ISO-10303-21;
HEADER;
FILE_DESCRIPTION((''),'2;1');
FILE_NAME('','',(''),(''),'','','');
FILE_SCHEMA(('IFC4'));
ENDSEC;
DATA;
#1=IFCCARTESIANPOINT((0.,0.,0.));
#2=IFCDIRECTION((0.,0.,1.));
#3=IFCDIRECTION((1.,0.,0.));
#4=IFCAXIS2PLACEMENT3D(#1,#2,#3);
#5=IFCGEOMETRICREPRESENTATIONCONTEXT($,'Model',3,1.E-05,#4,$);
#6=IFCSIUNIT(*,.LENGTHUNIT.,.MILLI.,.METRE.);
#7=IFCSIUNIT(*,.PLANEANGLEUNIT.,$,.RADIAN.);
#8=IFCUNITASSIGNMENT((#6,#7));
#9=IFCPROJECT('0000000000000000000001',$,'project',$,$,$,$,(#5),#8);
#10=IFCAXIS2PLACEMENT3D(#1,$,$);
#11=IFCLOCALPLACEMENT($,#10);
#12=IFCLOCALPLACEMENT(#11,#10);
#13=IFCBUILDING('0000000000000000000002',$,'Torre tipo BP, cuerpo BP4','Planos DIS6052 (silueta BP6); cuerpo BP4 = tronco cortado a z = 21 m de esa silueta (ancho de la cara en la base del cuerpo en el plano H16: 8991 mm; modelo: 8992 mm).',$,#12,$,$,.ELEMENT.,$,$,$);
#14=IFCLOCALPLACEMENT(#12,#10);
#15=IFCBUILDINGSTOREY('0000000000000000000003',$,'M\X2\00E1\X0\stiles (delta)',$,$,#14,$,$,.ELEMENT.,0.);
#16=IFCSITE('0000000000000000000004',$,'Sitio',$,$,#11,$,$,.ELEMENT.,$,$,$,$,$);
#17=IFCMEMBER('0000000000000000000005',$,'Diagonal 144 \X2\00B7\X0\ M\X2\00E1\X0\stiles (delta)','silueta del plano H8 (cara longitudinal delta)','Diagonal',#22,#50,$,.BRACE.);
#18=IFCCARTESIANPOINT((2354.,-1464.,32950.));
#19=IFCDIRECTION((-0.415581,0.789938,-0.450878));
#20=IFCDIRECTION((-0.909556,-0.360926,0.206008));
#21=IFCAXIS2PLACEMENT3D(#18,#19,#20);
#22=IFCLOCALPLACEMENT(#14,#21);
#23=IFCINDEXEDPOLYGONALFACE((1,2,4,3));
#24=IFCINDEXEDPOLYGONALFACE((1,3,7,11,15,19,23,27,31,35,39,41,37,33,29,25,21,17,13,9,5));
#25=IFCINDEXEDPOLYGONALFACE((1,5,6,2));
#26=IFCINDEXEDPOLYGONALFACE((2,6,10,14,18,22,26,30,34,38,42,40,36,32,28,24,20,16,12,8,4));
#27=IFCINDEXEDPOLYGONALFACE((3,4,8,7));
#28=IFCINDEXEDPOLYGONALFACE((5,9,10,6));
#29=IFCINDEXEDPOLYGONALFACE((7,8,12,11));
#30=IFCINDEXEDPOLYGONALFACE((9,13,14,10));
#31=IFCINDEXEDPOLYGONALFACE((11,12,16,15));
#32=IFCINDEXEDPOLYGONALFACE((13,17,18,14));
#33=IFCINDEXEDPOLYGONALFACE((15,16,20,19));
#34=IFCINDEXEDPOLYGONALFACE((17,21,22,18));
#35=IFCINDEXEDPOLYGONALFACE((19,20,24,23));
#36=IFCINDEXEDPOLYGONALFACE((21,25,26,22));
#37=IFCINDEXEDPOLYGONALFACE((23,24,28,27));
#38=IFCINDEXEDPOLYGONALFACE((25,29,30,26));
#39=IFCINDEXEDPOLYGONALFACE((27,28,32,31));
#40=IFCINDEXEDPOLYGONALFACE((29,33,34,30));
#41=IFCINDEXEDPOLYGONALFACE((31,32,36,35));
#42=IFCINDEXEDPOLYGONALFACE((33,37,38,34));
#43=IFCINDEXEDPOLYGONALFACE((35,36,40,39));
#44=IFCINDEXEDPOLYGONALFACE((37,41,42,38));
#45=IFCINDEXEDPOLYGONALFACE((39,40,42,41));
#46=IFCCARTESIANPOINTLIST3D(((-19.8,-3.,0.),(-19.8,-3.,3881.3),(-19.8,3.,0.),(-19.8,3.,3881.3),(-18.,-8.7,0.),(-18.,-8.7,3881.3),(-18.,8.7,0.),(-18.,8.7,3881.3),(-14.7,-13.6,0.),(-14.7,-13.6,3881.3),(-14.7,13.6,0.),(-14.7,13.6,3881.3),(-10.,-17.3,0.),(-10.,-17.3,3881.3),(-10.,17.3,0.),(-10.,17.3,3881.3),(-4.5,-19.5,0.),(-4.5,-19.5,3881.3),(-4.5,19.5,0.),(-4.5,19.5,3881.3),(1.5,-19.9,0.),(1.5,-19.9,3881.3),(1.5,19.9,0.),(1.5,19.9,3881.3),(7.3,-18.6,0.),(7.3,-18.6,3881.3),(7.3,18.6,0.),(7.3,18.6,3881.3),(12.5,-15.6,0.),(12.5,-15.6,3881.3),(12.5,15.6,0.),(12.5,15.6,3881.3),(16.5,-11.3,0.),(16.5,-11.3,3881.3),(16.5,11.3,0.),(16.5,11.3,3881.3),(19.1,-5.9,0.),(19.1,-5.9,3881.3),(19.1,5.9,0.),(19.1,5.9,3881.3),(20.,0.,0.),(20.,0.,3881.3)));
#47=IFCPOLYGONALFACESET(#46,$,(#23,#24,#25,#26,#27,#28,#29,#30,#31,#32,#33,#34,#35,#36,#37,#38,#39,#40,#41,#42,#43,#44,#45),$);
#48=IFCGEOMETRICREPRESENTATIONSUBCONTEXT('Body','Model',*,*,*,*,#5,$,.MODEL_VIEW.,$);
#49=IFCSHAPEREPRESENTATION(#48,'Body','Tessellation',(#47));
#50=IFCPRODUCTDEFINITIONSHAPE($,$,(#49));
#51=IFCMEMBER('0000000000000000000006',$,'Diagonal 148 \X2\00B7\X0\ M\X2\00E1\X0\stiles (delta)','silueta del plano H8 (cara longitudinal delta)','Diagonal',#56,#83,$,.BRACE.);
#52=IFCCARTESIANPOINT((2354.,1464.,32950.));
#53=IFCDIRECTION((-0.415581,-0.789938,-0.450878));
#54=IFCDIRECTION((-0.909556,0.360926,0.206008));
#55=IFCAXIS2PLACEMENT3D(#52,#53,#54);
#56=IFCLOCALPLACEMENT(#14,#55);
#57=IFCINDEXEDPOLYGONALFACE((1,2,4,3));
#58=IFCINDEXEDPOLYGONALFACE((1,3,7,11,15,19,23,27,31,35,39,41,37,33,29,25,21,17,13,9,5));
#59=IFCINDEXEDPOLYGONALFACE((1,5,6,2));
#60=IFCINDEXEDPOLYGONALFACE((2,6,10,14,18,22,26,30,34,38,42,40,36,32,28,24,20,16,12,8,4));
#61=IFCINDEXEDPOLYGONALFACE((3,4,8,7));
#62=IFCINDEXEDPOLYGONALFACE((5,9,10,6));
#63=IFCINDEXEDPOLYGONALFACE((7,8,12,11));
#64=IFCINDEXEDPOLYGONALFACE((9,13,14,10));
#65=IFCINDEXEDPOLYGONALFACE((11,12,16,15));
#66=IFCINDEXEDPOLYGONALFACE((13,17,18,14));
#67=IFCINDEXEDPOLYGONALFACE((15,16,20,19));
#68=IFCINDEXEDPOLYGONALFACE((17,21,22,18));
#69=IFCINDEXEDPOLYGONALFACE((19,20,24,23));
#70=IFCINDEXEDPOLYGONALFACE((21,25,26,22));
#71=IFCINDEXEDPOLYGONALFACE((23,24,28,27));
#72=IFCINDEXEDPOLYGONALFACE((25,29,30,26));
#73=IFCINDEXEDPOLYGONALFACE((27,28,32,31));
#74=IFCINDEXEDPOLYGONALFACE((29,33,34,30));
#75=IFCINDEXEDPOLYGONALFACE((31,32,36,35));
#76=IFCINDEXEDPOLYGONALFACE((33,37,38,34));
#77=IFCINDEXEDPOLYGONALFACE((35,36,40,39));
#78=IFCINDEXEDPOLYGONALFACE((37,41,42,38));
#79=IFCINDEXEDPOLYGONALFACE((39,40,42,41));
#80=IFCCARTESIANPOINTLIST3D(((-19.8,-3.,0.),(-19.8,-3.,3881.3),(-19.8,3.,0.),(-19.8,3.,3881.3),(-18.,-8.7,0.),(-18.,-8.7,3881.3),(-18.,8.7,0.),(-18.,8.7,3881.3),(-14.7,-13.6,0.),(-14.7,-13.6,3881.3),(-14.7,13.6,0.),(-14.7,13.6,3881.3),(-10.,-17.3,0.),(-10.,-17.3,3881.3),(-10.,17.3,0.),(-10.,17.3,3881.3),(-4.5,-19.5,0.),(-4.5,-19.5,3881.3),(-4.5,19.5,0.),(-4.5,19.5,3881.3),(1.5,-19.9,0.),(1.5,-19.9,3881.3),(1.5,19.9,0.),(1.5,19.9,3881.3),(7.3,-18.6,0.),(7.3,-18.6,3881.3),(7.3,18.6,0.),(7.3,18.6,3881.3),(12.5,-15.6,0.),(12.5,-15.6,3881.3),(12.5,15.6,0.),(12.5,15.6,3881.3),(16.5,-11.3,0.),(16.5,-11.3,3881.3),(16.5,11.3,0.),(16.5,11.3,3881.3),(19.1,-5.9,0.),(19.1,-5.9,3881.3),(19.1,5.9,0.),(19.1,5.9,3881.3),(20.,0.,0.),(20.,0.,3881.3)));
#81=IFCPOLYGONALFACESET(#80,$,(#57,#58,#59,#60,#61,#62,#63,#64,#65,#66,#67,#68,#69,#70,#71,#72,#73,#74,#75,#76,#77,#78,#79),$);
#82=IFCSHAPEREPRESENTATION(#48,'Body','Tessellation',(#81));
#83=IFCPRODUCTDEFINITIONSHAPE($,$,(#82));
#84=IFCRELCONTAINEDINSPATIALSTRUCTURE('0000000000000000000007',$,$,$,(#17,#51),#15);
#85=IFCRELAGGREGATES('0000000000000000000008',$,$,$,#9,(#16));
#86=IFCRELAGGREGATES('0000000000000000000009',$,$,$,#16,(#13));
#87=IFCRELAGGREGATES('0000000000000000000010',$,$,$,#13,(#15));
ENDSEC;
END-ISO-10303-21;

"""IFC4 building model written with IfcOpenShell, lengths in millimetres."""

from ifc_helpers import new_model, si_unit, frame, origin, origin_with_axes, place, context, subcontext, project, spatial, circle, extrude, element, save


model = new_model("IFC4")

# Units and contexts
model_context = context("Model", 3, precision=1e-05, world=origin_with_axes())
body_context = subcontext(model_context, "Body", "Model", "MODEL_VIEW")
ifc_project = project(units=[si_unit("LENGTHUNIT", "METRE", prefix="MILLI"), si_unit("PLANEANGLEUNIT", "RADIAN")], contexts=[model_context])

# Site, building, storey
site_placement = place(None, origin())
site = spatial("IfcSite", under=ifc_project, at=site_placement, Name="Sitio", CompositionType="ELEMENT")
building_placement = place(site_placement, origin())
building = spatial("IfcBuilding", under=site, at=building_placement, Name="Torre tipo BP, cuerpo BP4", Description="Planos DIS6052 (silueta BP6); cuerpo BP4 = tronco cortado a z = 21 m de esa silueta (ancho de la cara en la base del cuerpo en el plano H16: 8991 mm; modelo: 8992 mm).", CompositionType="ELEMENT")
storey_placement = place(building_placement, origin())
storey = spatial("IfcBuildingStorey", under=building, at=storey_placement, Name="Mástiles (delta)", CompositionType="ELEMENT", Elevation=0.0)

# Members
for number, where, z_axis, x_axis, name in (
    (1, (2354.0, -1464.0, 32950.0), (-0.415581, 0.789938, -0.450878), (-0.909556, -0.360926, 0.206008), "Diagonal 144 · Mástiles (delta)"),
    (2, (2354.0, 1464.0, 32950.0), (-0.415581, -0.789938, -0.450878), (-0.909556, 0.360926, 0.206008), "Diagonal 148 · Mástiles (delta)"),
):
    element("IfcMember", number, at=place(storey_placement, frame(where, z_axis=z_axis, x_axis=x_axis)), inside=storey, Name=name, Description="silueta del plano H8 (cara longitudinal delta)", ObjectType="Diagonal", PredefinedType="BRACE", context=body_context, shape_type="SweptSolid", body=[
        extrude(circle(Radius=20.0), None, (0.0, 0.0, 1.0), 3881.3),
    ])

save(model, "model.ifc")
